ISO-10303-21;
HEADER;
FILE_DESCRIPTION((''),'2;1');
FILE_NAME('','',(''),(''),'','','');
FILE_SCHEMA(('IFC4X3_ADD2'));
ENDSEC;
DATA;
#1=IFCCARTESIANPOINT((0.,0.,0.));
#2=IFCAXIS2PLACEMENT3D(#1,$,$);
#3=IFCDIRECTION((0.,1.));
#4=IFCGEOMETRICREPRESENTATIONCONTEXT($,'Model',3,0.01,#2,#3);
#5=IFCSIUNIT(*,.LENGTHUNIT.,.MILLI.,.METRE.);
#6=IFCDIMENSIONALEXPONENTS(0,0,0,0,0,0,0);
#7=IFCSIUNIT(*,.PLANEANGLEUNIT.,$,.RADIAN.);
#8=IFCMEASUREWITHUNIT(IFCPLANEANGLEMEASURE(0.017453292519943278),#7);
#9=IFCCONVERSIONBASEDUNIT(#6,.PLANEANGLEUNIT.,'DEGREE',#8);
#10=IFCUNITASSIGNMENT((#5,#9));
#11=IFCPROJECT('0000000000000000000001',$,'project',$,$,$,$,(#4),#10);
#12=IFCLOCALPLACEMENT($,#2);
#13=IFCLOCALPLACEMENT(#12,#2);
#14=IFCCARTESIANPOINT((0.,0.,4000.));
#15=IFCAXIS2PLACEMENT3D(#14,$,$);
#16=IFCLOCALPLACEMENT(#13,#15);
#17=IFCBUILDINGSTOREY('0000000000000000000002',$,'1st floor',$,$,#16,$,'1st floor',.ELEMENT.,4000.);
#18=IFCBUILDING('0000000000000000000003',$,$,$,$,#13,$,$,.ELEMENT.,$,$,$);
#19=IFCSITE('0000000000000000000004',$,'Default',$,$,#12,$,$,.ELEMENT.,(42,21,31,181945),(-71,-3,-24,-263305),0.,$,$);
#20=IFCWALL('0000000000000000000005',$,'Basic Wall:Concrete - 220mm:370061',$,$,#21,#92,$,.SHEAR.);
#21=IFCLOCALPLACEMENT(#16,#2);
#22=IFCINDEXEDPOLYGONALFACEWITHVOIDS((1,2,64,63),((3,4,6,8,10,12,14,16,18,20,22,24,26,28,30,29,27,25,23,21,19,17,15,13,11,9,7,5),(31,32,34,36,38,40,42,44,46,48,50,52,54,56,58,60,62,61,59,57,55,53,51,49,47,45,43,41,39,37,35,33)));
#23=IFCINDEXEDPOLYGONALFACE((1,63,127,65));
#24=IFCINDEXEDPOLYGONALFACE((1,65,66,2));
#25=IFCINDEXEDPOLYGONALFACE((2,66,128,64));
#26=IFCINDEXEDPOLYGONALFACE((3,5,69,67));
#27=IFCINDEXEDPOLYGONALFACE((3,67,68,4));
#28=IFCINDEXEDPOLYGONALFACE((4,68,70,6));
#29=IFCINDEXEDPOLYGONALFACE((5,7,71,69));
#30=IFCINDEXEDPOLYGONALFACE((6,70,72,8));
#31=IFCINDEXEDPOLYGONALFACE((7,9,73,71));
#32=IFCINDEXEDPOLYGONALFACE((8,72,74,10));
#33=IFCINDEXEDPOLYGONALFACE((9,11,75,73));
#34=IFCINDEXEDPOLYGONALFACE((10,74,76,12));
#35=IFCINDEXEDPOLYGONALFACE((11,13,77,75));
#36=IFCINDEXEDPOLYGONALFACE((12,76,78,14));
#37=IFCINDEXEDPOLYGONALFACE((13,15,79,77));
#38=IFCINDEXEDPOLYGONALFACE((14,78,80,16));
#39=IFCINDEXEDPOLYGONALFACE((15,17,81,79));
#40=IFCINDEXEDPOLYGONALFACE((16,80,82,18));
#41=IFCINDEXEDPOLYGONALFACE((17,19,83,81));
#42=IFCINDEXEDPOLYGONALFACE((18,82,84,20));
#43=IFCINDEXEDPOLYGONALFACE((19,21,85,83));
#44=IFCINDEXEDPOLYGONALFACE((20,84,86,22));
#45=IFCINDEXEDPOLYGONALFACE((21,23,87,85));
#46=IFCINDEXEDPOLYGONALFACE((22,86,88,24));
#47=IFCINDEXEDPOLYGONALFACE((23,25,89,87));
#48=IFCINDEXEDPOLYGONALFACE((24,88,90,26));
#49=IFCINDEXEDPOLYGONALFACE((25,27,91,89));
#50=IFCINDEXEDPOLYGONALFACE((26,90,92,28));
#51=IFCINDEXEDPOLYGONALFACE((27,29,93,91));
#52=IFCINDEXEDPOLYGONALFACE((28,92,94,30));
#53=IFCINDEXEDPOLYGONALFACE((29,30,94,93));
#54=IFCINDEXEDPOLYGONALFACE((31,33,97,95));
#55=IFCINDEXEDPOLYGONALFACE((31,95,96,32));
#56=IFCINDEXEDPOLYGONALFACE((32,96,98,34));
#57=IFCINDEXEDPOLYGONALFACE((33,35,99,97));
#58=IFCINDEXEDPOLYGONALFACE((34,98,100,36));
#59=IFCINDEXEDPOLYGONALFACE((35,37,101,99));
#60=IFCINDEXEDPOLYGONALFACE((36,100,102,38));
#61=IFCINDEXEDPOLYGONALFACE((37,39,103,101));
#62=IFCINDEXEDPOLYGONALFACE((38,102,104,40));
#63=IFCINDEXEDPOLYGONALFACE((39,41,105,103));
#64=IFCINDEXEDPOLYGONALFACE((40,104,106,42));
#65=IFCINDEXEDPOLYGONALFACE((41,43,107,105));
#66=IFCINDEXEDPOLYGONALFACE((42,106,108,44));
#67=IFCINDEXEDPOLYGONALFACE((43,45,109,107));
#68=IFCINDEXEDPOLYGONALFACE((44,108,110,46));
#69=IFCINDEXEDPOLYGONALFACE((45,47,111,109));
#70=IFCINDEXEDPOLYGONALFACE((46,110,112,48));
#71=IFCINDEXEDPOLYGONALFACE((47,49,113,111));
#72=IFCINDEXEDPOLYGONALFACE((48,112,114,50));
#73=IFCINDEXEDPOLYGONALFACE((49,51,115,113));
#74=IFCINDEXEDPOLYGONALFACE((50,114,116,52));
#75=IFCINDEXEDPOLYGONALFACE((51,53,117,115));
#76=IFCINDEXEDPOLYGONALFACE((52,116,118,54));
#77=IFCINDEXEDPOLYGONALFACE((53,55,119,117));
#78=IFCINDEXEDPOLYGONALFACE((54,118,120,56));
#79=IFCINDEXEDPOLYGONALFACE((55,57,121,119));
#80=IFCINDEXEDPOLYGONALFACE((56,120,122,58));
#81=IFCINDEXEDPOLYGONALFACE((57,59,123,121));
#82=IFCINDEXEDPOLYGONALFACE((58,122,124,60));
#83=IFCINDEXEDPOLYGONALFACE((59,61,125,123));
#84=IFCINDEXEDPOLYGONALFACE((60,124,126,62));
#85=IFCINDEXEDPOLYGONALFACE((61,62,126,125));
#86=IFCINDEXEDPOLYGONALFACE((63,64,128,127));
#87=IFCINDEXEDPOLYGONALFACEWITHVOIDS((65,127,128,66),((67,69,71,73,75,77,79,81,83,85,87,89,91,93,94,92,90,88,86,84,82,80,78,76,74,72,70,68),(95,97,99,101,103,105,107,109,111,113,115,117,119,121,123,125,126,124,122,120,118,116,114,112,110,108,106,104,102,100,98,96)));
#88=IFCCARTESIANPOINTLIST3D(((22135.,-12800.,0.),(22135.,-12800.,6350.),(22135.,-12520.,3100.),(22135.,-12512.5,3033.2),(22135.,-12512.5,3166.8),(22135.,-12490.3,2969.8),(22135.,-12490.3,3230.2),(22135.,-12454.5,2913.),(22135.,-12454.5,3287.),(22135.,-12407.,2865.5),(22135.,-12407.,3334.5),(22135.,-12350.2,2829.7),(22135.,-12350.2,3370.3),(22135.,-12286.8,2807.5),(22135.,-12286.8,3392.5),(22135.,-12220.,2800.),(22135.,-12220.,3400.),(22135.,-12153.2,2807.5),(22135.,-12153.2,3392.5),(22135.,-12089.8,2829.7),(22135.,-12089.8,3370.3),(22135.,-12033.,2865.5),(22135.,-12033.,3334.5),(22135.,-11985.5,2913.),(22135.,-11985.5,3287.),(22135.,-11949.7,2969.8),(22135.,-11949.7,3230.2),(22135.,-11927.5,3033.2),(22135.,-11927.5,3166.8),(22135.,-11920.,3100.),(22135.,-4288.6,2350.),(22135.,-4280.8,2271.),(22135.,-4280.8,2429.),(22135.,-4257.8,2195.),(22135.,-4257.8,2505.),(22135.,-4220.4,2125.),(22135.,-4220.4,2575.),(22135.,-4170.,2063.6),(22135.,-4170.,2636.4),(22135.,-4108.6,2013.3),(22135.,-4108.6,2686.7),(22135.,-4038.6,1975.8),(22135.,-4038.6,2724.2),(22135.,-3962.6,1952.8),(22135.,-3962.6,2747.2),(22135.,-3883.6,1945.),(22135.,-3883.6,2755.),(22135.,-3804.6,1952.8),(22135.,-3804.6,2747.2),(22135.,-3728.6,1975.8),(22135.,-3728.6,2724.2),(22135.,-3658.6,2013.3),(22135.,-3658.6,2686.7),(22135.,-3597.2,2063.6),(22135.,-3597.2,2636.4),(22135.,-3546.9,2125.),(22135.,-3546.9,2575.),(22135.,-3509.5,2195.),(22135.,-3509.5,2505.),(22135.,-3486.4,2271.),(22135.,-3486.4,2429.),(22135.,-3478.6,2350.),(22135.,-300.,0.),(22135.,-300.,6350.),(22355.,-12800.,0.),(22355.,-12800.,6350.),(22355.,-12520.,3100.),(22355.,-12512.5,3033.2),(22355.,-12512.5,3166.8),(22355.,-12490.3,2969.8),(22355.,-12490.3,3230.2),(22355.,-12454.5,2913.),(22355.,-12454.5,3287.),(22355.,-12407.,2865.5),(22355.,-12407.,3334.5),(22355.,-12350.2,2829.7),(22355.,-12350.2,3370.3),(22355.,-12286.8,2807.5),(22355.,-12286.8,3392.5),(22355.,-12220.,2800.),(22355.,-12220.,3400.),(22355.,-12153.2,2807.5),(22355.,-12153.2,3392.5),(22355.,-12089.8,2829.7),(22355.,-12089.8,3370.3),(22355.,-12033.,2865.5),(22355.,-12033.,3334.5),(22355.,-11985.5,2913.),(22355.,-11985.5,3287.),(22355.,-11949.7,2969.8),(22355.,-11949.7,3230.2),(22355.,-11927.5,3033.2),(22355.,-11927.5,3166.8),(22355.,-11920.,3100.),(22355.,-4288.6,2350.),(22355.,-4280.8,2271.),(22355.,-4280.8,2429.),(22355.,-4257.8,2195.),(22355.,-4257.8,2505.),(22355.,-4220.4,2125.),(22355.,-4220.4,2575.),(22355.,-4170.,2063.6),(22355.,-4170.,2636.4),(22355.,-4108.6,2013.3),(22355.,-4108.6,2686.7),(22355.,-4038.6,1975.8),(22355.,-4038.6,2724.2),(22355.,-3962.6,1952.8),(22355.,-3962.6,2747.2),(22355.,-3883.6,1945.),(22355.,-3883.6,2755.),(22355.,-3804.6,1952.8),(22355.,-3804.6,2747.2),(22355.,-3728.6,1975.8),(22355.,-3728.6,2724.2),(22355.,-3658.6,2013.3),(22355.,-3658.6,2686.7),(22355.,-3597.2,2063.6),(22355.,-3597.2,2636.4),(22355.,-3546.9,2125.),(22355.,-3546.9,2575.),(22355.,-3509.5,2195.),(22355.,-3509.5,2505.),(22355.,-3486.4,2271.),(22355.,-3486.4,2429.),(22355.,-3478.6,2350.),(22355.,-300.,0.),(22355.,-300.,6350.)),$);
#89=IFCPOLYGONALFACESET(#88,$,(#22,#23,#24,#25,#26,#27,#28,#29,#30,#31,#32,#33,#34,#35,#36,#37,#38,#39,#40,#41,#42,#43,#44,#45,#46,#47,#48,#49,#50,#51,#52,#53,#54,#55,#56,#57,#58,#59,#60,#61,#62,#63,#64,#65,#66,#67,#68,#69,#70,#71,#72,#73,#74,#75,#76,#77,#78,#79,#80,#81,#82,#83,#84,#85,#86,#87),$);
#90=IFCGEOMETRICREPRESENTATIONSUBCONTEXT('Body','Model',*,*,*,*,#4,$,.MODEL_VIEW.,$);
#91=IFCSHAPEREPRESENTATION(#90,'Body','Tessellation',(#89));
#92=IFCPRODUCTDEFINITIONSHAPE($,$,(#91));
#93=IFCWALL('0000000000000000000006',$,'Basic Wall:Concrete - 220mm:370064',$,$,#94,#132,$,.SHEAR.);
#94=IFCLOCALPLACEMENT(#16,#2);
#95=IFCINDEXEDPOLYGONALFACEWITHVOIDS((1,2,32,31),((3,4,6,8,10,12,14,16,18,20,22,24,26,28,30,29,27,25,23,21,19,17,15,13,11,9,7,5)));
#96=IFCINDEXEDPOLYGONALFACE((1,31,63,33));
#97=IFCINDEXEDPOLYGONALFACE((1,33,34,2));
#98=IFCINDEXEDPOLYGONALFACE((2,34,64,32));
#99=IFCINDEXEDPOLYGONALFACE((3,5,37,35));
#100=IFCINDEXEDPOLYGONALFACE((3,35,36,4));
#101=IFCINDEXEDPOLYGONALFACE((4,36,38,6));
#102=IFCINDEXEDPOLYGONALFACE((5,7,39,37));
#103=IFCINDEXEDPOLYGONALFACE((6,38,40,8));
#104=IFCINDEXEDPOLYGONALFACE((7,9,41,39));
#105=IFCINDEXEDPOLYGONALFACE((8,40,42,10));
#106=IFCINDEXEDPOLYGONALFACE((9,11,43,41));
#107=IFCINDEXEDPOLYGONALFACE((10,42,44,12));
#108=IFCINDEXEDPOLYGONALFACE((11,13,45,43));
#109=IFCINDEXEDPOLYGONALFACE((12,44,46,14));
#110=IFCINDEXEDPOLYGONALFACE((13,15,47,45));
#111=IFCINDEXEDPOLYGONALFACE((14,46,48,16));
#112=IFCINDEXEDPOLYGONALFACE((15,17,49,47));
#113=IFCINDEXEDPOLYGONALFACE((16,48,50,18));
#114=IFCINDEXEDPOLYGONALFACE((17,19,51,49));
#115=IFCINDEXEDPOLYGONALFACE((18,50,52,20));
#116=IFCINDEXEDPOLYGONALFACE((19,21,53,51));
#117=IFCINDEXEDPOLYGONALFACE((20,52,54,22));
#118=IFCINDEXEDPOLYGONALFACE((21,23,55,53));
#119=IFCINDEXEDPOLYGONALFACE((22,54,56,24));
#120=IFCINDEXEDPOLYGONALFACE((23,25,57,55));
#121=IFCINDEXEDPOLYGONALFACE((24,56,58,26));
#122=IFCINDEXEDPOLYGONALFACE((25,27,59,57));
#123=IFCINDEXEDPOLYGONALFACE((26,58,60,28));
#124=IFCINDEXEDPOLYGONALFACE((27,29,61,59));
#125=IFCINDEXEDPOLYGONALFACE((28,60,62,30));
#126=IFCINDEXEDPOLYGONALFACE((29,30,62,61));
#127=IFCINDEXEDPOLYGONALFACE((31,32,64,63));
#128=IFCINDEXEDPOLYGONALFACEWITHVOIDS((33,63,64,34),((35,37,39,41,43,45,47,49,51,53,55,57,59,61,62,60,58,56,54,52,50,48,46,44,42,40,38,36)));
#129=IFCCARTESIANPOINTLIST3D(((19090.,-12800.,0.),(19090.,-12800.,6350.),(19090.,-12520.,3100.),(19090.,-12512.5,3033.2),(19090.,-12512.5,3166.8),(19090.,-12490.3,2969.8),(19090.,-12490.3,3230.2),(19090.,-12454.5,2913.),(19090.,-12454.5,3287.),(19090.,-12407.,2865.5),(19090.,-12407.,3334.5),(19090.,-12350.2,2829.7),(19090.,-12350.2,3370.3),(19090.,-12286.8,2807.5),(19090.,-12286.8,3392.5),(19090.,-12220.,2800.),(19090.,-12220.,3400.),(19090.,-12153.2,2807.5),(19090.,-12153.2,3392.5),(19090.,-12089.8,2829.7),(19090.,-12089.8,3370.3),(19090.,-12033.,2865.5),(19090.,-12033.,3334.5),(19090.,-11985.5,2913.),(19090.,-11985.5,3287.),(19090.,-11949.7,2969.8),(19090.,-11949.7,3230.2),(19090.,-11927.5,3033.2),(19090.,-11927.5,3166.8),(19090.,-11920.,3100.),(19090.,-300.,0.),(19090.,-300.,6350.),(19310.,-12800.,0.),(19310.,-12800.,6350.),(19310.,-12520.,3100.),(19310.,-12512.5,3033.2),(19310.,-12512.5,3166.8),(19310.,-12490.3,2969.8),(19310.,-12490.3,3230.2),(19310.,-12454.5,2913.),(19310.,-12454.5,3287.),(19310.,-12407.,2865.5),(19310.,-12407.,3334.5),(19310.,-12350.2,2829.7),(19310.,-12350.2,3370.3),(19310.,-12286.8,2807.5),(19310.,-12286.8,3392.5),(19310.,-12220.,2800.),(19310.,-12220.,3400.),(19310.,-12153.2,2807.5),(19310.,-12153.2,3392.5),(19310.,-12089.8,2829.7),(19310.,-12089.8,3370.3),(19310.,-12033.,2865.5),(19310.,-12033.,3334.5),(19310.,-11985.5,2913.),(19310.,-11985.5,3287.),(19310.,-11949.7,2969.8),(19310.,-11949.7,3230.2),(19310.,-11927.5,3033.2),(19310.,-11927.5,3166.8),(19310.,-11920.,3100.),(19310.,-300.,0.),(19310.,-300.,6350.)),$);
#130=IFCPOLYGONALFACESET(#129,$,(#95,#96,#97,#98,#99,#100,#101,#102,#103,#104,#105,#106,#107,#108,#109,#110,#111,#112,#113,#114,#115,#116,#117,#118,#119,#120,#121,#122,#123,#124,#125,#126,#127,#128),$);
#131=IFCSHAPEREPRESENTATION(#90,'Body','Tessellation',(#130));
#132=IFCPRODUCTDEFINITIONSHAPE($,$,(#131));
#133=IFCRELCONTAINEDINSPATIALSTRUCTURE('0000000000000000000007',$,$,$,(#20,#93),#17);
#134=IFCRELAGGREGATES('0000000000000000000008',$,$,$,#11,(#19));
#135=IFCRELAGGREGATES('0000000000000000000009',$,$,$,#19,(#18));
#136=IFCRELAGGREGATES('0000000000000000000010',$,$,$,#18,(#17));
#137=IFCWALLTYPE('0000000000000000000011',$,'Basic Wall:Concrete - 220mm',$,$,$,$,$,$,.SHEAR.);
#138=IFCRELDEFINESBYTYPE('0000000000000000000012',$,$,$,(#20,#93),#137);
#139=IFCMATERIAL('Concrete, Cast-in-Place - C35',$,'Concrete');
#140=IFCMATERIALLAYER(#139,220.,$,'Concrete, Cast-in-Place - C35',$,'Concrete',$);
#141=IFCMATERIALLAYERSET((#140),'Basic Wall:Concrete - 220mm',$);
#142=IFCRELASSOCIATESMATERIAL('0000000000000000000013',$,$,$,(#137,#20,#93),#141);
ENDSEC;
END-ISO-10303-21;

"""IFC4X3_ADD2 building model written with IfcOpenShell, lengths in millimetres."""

from ifc_helpers import new_model, entity, si_unit, converted_unit, direction, frame, frame_2d, origin, place, context, subcontext, project, spatial, rectangle, circle, extrude, material, layer, layer_set, type_object, element, save


model = new_model("IFC4X3_ADD2")

# Units and contexts
model_context = context("Model", 3, precision=0.01, world=origin(), true_north=direction((0.0, 1.0)))
body_context = subcontext(model_context, "Body", "Model", "MODEL_VIEW")
ifc_project = project(units=[si_unit("LENGTHUNIT", "METRE", prefix="MILLI"), converted_unit("PLANEANGLEUNIT", "DEGREE", entity("IfcPlaneAngleMeasure", 0.017453292519943278), si_unit("PLANEANGLEUNIT", "RADIAN"), dimensions=[0, 0, 0, 0, 0, 0, 0])], contexts=[model_context])

# Site, building, storey
site_placement = place(None, origin())
site = spatial("IfcSite", under=ifc_project, at=site_placement, Name="Default", CompositionType="ELEMENT", RefLatitude=(42, 21, 31, 181945), RefLongitude=(-71, -3, -24, -263305), RefElevation=0.0)
building_placement = place(site_placement, origin())
building = spatial("IfcBuilding", under=site, at=building_placement, CompositionType="ELEMENT")
storey_placement = place(building_placement, frame((0.0, 0.0, 4000.0)))
storey = spatial("IfcBuildingStorey", under=building, at=storey_placement, Name="1st floor", LongName="1st floor", CompositionType="ELEMENT", Elevation=4000.0)

# Shared definitions
ifc_material_1 = material(Name="Concrete, Cast-in-Place - C35", Category="Concrete")

# Wall, openings
ifc_layer = layer(ifc_material_1, 220.0, Name="Concrete, Cast-in-Place - C35", Category="Concrete")
ifc_layer_set = layer_set([ifc_layer], Name="Basic Wall:Concrete - 220mm")
wall_type = type_object("IfcWallType", Name="Basic Wall:Concrete - 220mm", PredefinedType="SHEAR", material=ifc_layer_set)
wall_1_placement = place(storey_placement, frame((22245.0, -300.0, 0.0), z_axis=(0.0, 0.0, 1.0), x_axis=(0.0, -1.0, 0.0)))
wall_1 = element("IfcWall", 1, at=wall_1_placement, inside=storey, type_object=wall_type, material=ifc_layer_set, Name="Basic Wall:Concrete - 220mm:370061", PredefinedType="SHEAR", context=body_context, shape_type="SweptSolid", body=[
    extrude(rectangle(XDim=12500.0, YDim=220.0, at=frame_2d((6250.0, 0.0), x_axis=(-1.0, 0.0))), origin(), (0.0, 0.0, 1.0), 6350.0),
])
opening_1_placement = place(wall_1_placement, frame((-300.0, -22245.0, 1945.0)))
element("IfcOpeningElement", 2, at=opening_1_placement, cuts=wall_1, PredefinedType="OPENING", context=body_context, shape_type="SweptSolid", body=[
    extrude(circle(Radius=405.0, at=frame_2d((0.0, 0.0), x_axis=(1.0, 0.0))), frame((3883.6, 21995.0, 405.0), z_axis=(0.0, 1.0, 0.0), x_axis=(-1.0, 0.0, 0.0)), (0.0, 0.0, 1.0), 500.0),
])
opening_2_placement = place(wall_1_placement, frame((-300.0, -22245.0, 2800.0)))
element("IfcOpeningElement", 3, at=opening_2_placement, cuts=wall_1, PredefinedType="OPENING", context=body_context, shape_type="SweptSolid", body=[
    extrude(circle(Radius=300.0, at=frame_2d((0.0, 0.0), x_axis=(1.0, 0.0))), frame((12220.0, 21995.0, 300.0), z_axis=(0.0, 1.0, 0.0), x_axis=(-1.0, 0.0, 0.0)), (0.0, 0.0, 1.0), 500.0),
])

# Wall, opening
wall_2_placement = place(storey_placement, frame((19200.0, -300.0, 0.0), z_axis=(0.0, 0.0, 1.0), x_axis=(0.0, -1.0, 0.0)))
wall_2 = element("IfcWall", 4, at=wall_2_placement, inside=storey, type_object=wall_type, material=ifc_layer_set, Name="Basic Wall:Concrete - 220mm:370064", PredefinedType="SHEAR", context=body_context, shape_type="SweptSolid", body=[
    extrude(rectangle(XDim=12500.0, YDim=220.0, at=frame_2d((6250.0, 0.0), x_axis=(-1.0, 0.0))), origin(), (0.0, 0.0, 1.0), 6350.0),
])
opening_3_placement = place(wall_2_placement, frame((-300.0, -19200.0, 2800.0)))
element("IfcOpeningElement", 5, at=opening_3_placement, cuts=wall_2, PredefinedType="OPENING", context=body_context, shape_type="SweptSolid", body=[
    extrude(circle(Radius=300.0, at=frame_2d((0.0, 0.0), x_axis=(1.0, 0.0))), frame((12220.0, 18950.0, 300.0), z_axis=(0.0, 1.0, 0.0), x_axis=(1.0, 0.0, 0.0)), (0.0, 0.0, 1.0), 500.0),
])

save(model, "model.ifc")
